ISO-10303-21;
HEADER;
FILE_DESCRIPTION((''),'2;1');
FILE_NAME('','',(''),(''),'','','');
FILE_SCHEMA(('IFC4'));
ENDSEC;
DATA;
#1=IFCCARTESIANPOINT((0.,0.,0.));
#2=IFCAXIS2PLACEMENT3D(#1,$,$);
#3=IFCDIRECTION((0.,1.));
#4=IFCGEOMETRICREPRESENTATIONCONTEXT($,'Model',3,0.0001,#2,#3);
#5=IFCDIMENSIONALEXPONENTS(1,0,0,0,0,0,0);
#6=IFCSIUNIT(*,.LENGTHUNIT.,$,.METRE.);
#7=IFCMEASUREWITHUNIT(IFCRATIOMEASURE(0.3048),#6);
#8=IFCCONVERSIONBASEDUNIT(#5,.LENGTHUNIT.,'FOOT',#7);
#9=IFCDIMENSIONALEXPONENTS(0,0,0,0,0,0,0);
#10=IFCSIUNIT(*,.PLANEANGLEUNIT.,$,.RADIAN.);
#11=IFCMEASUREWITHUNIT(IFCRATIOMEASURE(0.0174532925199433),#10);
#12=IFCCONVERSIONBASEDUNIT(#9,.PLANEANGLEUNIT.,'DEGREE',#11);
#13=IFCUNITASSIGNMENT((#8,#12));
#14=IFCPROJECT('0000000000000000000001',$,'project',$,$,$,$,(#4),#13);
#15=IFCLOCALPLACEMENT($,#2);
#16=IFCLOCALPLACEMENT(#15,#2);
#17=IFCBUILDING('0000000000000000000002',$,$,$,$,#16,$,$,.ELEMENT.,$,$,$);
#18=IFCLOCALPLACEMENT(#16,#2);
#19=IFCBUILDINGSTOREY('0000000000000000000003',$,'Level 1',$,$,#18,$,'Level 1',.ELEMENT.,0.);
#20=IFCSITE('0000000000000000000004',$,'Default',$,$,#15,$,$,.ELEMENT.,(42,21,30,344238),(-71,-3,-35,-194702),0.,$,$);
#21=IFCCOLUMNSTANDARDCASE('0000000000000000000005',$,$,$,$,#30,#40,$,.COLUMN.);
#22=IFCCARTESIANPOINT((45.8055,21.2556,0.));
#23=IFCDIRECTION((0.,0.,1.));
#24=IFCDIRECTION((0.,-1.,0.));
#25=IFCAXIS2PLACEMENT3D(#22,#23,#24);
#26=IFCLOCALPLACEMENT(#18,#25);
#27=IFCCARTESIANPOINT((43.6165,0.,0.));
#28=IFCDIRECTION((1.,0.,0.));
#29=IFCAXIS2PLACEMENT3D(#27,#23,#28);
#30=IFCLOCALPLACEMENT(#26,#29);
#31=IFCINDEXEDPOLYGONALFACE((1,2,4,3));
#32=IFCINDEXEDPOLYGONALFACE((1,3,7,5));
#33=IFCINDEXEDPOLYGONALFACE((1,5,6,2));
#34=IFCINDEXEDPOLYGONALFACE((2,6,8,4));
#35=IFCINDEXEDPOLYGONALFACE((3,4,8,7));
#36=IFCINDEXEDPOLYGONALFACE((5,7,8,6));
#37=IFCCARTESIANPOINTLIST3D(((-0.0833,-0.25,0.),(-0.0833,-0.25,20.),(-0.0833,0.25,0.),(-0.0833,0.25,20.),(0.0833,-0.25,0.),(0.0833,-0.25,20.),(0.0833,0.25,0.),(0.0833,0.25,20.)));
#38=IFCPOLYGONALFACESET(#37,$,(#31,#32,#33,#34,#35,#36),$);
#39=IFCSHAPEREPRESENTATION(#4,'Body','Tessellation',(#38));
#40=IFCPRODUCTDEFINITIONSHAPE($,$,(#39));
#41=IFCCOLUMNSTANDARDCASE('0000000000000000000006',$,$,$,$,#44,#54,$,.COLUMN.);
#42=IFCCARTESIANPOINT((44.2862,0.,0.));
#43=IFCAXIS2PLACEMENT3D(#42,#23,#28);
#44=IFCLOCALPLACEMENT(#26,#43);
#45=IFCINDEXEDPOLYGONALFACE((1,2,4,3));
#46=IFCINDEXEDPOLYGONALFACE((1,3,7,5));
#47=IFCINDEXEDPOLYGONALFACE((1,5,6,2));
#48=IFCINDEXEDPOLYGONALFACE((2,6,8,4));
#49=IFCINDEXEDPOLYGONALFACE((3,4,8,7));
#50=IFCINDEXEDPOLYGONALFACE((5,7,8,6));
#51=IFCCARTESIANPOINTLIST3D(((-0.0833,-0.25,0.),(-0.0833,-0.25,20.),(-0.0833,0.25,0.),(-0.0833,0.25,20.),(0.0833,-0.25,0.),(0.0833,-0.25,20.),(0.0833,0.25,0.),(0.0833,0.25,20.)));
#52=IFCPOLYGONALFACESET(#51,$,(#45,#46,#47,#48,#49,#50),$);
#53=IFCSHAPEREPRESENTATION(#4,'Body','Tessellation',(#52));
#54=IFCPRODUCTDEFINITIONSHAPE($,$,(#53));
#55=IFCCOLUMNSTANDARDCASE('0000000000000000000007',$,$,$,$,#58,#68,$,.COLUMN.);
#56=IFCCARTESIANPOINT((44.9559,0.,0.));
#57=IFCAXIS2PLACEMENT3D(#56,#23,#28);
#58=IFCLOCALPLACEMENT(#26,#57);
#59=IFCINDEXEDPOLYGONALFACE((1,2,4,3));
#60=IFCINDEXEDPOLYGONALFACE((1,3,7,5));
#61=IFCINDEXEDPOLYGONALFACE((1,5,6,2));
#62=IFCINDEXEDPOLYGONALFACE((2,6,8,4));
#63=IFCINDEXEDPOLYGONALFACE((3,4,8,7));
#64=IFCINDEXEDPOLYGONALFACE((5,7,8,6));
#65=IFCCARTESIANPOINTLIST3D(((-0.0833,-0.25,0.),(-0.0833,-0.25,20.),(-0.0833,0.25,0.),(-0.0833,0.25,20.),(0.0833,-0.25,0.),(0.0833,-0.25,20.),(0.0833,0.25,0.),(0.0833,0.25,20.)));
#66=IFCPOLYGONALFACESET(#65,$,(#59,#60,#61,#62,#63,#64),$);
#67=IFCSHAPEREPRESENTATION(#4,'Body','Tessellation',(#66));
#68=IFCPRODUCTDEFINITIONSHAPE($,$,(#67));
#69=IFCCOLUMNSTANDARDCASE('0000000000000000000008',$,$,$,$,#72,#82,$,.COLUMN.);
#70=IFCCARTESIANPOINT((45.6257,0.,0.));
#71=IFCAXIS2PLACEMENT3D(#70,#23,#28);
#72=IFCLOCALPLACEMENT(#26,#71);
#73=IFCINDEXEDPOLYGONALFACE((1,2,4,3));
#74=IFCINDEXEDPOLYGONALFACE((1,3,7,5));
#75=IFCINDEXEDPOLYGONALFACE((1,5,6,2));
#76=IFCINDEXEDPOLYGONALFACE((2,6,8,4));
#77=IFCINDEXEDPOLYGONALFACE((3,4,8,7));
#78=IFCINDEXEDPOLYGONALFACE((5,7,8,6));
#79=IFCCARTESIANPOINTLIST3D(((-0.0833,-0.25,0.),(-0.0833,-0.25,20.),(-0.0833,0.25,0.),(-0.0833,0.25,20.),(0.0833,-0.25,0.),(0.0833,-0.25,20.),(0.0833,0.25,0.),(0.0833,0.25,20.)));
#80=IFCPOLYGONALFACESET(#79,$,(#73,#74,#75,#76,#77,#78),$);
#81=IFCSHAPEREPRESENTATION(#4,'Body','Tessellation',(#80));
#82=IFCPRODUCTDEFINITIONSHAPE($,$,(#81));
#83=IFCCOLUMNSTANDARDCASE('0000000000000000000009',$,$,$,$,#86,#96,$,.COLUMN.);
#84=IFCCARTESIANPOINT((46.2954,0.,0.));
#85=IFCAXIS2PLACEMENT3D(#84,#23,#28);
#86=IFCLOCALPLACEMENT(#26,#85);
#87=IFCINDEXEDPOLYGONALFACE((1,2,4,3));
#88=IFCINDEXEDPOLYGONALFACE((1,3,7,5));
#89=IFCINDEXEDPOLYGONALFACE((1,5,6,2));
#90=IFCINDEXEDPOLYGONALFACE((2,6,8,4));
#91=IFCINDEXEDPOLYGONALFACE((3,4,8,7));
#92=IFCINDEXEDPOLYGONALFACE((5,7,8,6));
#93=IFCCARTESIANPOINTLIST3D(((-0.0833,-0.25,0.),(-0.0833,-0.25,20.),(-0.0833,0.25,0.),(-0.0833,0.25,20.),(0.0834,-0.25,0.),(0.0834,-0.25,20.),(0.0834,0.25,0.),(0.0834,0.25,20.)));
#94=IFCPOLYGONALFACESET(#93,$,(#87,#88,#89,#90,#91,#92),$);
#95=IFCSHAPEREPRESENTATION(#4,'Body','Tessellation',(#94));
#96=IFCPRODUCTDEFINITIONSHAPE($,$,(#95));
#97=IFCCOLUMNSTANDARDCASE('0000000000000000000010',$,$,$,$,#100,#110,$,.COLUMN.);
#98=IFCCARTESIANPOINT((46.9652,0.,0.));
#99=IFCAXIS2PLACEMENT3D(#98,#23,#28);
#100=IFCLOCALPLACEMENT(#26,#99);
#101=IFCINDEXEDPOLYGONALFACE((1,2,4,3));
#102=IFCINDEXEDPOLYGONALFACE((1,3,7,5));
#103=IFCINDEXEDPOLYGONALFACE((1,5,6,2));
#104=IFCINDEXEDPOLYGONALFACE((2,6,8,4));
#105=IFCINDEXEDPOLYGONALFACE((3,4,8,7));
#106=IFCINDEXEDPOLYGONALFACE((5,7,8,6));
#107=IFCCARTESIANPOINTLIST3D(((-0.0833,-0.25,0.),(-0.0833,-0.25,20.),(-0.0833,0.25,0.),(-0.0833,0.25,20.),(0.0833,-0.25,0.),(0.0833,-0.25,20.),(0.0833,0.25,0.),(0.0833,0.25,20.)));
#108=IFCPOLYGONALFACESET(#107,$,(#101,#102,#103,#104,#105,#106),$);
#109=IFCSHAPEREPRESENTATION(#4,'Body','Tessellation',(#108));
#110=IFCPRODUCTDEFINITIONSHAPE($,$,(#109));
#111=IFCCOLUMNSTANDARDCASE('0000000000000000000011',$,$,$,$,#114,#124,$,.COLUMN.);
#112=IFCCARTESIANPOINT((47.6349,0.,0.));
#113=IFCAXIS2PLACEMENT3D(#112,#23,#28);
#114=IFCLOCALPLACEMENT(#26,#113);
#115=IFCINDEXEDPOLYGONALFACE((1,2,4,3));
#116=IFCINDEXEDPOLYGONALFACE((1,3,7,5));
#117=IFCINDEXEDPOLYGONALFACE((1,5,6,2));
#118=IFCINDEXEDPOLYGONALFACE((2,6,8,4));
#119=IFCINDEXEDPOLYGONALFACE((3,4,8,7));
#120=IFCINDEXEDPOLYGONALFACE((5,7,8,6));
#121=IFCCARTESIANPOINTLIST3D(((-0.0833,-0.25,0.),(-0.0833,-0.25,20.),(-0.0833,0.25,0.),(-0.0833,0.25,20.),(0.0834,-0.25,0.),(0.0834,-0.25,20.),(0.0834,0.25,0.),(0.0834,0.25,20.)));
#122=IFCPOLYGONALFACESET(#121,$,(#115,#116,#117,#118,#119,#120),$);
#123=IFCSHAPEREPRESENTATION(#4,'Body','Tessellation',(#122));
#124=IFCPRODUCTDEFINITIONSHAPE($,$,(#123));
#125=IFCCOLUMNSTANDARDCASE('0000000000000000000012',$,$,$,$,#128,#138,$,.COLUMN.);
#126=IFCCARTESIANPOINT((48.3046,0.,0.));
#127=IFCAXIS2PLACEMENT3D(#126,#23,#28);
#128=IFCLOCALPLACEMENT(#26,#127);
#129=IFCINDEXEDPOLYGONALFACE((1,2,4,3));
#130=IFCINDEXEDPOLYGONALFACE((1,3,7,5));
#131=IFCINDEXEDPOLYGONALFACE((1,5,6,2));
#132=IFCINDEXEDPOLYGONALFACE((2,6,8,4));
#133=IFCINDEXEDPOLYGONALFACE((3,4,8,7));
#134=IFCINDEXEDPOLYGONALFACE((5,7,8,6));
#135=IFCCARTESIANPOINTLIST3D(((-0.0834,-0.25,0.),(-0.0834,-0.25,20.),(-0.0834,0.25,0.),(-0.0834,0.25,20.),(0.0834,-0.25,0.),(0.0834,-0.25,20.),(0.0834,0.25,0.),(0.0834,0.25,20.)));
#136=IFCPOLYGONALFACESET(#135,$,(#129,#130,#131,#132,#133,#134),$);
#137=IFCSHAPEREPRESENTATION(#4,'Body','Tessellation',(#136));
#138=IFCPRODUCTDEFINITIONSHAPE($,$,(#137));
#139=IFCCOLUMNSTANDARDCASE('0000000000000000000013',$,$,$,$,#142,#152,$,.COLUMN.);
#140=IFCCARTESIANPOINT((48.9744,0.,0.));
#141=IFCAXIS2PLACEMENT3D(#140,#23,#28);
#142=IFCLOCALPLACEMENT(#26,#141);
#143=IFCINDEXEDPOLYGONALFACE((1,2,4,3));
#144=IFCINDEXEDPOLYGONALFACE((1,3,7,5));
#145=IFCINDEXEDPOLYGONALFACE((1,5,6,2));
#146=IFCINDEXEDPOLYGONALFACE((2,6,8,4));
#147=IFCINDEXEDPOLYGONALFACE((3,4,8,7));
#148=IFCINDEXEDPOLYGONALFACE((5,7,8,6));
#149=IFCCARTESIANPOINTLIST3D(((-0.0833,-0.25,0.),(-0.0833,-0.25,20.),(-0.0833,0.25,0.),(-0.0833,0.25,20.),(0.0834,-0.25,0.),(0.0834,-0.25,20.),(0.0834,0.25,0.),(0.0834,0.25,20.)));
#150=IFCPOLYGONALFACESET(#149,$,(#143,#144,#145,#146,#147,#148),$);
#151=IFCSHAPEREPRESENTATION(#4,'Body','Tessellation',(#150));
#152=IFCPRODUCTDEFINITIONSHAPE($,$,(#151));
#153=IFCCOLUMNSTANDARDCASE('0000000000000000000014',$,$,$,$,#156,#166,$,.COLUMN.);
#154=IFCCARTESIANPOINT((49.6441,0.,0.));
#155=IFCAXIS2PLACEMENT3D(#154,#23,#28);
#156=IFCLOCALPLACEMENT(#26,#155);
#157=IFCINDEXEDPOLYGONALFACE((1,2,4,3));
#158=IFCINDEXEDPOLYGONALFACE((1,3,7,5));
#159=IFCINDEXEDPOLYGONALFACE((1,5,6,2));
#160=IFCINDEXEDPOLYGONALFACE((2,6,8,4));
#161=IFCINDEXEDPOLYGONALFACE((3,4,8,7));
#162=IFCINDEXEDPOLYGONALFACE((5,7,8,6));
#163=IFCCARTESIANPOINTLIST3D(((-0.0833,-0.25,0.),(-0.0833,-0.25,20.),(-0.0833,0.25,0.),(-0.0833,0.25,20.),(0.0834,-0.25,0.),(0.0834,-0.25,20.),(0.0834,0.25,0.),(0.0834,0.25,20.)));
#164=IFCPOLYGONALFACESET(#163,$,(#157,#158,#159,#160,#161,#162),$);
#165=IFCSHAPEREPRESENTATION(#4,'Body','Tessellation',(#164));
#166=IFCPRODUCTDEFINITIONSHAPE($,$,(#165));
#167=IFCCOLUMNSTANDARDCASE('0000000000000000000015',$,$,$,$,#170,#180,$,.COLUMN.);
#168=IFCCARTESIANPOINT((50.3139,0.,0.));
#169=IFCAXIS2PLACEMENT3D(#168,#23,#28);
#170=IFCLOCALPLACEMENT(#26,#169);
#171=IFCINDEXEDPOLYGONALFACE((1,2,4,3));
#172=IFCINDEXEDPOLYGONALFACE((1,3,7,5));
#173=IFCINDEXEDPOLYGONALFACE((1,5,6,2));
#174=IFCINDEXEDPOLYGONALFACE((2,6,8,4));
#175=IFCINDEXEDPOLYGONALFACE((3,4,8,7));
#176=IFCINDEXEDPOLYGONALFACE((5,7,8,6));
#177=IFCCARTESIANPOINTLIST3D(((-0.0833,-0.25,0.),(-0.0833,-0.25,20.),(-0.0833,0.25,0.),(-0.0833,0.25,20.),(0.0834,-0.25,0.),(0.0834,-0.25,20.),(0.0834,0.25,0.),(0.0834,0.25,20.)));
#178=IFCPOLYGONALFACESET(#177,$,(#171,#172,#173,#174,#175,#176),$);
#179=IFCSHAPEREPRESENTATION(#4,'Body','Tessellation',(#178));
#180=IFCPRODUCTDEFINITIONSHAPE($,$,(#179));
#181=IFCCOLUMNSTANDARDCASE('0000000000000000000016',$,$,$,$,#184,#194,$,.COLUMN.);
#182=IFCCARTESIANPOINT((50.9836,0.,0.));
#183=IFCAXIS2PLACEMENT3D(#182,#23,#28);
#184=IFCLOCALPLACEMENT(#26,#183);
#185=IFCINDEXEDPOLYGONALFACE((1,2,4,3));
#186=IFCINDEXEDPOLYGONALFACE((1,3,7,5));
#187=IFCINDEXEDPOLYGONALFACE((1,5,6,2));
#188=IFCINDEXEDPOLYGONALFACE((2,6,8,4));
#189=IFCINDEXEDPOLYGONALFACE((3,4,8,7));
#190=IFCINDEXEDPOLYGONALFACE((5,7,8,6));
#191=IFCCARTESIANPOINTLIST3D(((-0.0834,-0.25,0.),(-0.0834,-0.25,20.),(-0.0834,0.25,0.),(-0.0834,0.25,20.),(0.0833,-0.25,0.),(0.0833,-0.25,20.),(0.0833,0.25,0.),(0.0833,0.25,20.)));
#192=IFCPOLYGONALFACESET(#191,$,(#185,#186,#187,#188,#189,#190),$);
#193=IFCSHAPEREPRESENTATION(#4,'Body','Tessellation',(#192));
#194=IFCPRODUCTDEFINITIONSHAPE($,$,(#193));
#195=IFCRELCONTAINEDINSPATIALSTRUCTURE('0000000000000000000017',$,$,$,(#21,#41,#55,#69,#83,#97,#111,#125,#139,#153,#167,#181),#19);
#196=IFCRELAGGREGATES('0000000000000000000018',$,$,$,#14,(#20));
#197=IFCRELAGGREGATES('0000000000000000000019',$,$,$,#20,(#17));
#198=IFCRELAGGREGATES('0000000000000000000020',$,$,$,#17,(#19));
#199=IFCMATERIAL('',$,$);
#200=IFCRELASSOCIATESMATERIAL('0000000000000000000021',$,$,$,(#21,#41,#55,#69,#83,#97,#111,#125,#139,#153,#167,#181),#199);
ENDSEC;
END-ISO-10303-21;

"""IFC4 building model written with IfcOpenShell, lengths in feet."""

from ifc_helpers import new_model, entity, si_unit, converted_unit, direction, frame, origin, place, context, project, spatial, rectangle, extrude, material, element, save


model = new_model("IFC4")

# Units and contexts
model_context = context("Model", 3, precision=0.0001, world=origin(), true_north=direction((0.0, 1.0)))
ifc_project = project(units=[converted_unit("LENGTHUNIT", "FOOT", entity("IfcRatioMeasure", 0.3048), si_unit("LENGTHUNIT", "METRE"), dimensions=[1, 0, 0, 0, 0, 0, 0]), converted_unit("PLANEANGLEUNIT", "DEGREE", entity("IfcRatioMeasure", 0.0174532925199433), si_unit("PLANEANGLEUNIT", "RADIAN"), dimensions=[0, 0, 0, 0, 0, 0, 0])], contexts=[model_context])

# Site, building, storey
site_placement = place(None, origin())
site = spatial("IfcSite", under=ifc_project, at=site_placement, Name="Default", CompositionType="ELEMENT", RefLatitude=(42, 21, 30, 344238), RefLongitude=(-71, -3, -35, -194702), RefElevation=0.0)
building_placement = place(site_placement, origin())
building = spatial("IfcBuilding", under=site, at=building_placement, CompositionType="ELEMENT")
storey_placement = place(building_placement, origin())
storey = spatial("IfcBuildingStorey", under=building, at=storey_placement, Name="Level 1", LongName="Level 1", CompositionType="ELEMENT", Elevation=0.0)

# Columns
ifc_material_1 = material(Name="")
placement = place(storey_placement, frame((45.8055, 21.2556, 0.0), z_axis=(0.0, 0.0, 1.0), x_axis=(0.0, -1.0, 0.0)))
for number, where, z_axis, x_axis in (
    (1, (43.6165, 0.0, 0.0), (0.0, 0.0, 1.0), (1.0, 0.0, 0.0)),
    (2, (44.2862, 0.0, 0.0), (0.0, 0.0, 1.0), (1.0, 0.0, 0.0)),
    (3, (44.9559, 0.0, 0.0), (0.0, 0.0, 1.0), (1.0, 0.0, 0.0)),
    (4, (45.6257, 0.0, 0.0), (0.0, 0.0, 1.0), (1.0, 0.0, 0.0)),
    (5, (46.2954, 0.0, 0.0), (0.0, 0.0, 1.0), (1.0, 0.0, 0.0)),
    (6, (46.9652, 0.0, 0.0), (0.0, 0.0, 1.0), (1.0, 0.0, 0.0)),
    (7, (47.6349, 0.0, 0.0), (0.0, 0.0, 1.0), (1.0, 0.0, 0.0)),
    (8, (48.3046, 0.0, 0.0), (0.0, 0.0, 1.0), (1.0, 0.0, 0.0)),
    (9, (48.9744, 0.0, 0.0), (0.0, 0.0, 1.0), (1.0, 0.0, 0.0)),
    (10, (49.6441, 0.0, 0.0), (0.0, 0.0, 1.0), (1.0, 0.0, 0.0)),
    (11, (50.3139, 0.0, 0.0), (0.0, 0.0, 1.0), (1.0, 0.0, 0.0)),
    (12, (50.9836, 0.0, 0.0), (0.0, 0.0, 1.0), (1.0, 0.0, 0.0)),
):
    element("IfcColumnStandardCase", number, at=place(placement, frame(where, z_axis=z_axis, x_axis=x_axis)), inside=storey, material=ifc_material_1, PredefinedType="COLUMN", context=model_context, shape_type="SweptSolid", body=[
        extrude(rectangle(XDim=0.1667, YDim=0.5), origin(), (0.0, 0.0, 1.0), 20.0),
    ])

save(model, "model.ifc")
